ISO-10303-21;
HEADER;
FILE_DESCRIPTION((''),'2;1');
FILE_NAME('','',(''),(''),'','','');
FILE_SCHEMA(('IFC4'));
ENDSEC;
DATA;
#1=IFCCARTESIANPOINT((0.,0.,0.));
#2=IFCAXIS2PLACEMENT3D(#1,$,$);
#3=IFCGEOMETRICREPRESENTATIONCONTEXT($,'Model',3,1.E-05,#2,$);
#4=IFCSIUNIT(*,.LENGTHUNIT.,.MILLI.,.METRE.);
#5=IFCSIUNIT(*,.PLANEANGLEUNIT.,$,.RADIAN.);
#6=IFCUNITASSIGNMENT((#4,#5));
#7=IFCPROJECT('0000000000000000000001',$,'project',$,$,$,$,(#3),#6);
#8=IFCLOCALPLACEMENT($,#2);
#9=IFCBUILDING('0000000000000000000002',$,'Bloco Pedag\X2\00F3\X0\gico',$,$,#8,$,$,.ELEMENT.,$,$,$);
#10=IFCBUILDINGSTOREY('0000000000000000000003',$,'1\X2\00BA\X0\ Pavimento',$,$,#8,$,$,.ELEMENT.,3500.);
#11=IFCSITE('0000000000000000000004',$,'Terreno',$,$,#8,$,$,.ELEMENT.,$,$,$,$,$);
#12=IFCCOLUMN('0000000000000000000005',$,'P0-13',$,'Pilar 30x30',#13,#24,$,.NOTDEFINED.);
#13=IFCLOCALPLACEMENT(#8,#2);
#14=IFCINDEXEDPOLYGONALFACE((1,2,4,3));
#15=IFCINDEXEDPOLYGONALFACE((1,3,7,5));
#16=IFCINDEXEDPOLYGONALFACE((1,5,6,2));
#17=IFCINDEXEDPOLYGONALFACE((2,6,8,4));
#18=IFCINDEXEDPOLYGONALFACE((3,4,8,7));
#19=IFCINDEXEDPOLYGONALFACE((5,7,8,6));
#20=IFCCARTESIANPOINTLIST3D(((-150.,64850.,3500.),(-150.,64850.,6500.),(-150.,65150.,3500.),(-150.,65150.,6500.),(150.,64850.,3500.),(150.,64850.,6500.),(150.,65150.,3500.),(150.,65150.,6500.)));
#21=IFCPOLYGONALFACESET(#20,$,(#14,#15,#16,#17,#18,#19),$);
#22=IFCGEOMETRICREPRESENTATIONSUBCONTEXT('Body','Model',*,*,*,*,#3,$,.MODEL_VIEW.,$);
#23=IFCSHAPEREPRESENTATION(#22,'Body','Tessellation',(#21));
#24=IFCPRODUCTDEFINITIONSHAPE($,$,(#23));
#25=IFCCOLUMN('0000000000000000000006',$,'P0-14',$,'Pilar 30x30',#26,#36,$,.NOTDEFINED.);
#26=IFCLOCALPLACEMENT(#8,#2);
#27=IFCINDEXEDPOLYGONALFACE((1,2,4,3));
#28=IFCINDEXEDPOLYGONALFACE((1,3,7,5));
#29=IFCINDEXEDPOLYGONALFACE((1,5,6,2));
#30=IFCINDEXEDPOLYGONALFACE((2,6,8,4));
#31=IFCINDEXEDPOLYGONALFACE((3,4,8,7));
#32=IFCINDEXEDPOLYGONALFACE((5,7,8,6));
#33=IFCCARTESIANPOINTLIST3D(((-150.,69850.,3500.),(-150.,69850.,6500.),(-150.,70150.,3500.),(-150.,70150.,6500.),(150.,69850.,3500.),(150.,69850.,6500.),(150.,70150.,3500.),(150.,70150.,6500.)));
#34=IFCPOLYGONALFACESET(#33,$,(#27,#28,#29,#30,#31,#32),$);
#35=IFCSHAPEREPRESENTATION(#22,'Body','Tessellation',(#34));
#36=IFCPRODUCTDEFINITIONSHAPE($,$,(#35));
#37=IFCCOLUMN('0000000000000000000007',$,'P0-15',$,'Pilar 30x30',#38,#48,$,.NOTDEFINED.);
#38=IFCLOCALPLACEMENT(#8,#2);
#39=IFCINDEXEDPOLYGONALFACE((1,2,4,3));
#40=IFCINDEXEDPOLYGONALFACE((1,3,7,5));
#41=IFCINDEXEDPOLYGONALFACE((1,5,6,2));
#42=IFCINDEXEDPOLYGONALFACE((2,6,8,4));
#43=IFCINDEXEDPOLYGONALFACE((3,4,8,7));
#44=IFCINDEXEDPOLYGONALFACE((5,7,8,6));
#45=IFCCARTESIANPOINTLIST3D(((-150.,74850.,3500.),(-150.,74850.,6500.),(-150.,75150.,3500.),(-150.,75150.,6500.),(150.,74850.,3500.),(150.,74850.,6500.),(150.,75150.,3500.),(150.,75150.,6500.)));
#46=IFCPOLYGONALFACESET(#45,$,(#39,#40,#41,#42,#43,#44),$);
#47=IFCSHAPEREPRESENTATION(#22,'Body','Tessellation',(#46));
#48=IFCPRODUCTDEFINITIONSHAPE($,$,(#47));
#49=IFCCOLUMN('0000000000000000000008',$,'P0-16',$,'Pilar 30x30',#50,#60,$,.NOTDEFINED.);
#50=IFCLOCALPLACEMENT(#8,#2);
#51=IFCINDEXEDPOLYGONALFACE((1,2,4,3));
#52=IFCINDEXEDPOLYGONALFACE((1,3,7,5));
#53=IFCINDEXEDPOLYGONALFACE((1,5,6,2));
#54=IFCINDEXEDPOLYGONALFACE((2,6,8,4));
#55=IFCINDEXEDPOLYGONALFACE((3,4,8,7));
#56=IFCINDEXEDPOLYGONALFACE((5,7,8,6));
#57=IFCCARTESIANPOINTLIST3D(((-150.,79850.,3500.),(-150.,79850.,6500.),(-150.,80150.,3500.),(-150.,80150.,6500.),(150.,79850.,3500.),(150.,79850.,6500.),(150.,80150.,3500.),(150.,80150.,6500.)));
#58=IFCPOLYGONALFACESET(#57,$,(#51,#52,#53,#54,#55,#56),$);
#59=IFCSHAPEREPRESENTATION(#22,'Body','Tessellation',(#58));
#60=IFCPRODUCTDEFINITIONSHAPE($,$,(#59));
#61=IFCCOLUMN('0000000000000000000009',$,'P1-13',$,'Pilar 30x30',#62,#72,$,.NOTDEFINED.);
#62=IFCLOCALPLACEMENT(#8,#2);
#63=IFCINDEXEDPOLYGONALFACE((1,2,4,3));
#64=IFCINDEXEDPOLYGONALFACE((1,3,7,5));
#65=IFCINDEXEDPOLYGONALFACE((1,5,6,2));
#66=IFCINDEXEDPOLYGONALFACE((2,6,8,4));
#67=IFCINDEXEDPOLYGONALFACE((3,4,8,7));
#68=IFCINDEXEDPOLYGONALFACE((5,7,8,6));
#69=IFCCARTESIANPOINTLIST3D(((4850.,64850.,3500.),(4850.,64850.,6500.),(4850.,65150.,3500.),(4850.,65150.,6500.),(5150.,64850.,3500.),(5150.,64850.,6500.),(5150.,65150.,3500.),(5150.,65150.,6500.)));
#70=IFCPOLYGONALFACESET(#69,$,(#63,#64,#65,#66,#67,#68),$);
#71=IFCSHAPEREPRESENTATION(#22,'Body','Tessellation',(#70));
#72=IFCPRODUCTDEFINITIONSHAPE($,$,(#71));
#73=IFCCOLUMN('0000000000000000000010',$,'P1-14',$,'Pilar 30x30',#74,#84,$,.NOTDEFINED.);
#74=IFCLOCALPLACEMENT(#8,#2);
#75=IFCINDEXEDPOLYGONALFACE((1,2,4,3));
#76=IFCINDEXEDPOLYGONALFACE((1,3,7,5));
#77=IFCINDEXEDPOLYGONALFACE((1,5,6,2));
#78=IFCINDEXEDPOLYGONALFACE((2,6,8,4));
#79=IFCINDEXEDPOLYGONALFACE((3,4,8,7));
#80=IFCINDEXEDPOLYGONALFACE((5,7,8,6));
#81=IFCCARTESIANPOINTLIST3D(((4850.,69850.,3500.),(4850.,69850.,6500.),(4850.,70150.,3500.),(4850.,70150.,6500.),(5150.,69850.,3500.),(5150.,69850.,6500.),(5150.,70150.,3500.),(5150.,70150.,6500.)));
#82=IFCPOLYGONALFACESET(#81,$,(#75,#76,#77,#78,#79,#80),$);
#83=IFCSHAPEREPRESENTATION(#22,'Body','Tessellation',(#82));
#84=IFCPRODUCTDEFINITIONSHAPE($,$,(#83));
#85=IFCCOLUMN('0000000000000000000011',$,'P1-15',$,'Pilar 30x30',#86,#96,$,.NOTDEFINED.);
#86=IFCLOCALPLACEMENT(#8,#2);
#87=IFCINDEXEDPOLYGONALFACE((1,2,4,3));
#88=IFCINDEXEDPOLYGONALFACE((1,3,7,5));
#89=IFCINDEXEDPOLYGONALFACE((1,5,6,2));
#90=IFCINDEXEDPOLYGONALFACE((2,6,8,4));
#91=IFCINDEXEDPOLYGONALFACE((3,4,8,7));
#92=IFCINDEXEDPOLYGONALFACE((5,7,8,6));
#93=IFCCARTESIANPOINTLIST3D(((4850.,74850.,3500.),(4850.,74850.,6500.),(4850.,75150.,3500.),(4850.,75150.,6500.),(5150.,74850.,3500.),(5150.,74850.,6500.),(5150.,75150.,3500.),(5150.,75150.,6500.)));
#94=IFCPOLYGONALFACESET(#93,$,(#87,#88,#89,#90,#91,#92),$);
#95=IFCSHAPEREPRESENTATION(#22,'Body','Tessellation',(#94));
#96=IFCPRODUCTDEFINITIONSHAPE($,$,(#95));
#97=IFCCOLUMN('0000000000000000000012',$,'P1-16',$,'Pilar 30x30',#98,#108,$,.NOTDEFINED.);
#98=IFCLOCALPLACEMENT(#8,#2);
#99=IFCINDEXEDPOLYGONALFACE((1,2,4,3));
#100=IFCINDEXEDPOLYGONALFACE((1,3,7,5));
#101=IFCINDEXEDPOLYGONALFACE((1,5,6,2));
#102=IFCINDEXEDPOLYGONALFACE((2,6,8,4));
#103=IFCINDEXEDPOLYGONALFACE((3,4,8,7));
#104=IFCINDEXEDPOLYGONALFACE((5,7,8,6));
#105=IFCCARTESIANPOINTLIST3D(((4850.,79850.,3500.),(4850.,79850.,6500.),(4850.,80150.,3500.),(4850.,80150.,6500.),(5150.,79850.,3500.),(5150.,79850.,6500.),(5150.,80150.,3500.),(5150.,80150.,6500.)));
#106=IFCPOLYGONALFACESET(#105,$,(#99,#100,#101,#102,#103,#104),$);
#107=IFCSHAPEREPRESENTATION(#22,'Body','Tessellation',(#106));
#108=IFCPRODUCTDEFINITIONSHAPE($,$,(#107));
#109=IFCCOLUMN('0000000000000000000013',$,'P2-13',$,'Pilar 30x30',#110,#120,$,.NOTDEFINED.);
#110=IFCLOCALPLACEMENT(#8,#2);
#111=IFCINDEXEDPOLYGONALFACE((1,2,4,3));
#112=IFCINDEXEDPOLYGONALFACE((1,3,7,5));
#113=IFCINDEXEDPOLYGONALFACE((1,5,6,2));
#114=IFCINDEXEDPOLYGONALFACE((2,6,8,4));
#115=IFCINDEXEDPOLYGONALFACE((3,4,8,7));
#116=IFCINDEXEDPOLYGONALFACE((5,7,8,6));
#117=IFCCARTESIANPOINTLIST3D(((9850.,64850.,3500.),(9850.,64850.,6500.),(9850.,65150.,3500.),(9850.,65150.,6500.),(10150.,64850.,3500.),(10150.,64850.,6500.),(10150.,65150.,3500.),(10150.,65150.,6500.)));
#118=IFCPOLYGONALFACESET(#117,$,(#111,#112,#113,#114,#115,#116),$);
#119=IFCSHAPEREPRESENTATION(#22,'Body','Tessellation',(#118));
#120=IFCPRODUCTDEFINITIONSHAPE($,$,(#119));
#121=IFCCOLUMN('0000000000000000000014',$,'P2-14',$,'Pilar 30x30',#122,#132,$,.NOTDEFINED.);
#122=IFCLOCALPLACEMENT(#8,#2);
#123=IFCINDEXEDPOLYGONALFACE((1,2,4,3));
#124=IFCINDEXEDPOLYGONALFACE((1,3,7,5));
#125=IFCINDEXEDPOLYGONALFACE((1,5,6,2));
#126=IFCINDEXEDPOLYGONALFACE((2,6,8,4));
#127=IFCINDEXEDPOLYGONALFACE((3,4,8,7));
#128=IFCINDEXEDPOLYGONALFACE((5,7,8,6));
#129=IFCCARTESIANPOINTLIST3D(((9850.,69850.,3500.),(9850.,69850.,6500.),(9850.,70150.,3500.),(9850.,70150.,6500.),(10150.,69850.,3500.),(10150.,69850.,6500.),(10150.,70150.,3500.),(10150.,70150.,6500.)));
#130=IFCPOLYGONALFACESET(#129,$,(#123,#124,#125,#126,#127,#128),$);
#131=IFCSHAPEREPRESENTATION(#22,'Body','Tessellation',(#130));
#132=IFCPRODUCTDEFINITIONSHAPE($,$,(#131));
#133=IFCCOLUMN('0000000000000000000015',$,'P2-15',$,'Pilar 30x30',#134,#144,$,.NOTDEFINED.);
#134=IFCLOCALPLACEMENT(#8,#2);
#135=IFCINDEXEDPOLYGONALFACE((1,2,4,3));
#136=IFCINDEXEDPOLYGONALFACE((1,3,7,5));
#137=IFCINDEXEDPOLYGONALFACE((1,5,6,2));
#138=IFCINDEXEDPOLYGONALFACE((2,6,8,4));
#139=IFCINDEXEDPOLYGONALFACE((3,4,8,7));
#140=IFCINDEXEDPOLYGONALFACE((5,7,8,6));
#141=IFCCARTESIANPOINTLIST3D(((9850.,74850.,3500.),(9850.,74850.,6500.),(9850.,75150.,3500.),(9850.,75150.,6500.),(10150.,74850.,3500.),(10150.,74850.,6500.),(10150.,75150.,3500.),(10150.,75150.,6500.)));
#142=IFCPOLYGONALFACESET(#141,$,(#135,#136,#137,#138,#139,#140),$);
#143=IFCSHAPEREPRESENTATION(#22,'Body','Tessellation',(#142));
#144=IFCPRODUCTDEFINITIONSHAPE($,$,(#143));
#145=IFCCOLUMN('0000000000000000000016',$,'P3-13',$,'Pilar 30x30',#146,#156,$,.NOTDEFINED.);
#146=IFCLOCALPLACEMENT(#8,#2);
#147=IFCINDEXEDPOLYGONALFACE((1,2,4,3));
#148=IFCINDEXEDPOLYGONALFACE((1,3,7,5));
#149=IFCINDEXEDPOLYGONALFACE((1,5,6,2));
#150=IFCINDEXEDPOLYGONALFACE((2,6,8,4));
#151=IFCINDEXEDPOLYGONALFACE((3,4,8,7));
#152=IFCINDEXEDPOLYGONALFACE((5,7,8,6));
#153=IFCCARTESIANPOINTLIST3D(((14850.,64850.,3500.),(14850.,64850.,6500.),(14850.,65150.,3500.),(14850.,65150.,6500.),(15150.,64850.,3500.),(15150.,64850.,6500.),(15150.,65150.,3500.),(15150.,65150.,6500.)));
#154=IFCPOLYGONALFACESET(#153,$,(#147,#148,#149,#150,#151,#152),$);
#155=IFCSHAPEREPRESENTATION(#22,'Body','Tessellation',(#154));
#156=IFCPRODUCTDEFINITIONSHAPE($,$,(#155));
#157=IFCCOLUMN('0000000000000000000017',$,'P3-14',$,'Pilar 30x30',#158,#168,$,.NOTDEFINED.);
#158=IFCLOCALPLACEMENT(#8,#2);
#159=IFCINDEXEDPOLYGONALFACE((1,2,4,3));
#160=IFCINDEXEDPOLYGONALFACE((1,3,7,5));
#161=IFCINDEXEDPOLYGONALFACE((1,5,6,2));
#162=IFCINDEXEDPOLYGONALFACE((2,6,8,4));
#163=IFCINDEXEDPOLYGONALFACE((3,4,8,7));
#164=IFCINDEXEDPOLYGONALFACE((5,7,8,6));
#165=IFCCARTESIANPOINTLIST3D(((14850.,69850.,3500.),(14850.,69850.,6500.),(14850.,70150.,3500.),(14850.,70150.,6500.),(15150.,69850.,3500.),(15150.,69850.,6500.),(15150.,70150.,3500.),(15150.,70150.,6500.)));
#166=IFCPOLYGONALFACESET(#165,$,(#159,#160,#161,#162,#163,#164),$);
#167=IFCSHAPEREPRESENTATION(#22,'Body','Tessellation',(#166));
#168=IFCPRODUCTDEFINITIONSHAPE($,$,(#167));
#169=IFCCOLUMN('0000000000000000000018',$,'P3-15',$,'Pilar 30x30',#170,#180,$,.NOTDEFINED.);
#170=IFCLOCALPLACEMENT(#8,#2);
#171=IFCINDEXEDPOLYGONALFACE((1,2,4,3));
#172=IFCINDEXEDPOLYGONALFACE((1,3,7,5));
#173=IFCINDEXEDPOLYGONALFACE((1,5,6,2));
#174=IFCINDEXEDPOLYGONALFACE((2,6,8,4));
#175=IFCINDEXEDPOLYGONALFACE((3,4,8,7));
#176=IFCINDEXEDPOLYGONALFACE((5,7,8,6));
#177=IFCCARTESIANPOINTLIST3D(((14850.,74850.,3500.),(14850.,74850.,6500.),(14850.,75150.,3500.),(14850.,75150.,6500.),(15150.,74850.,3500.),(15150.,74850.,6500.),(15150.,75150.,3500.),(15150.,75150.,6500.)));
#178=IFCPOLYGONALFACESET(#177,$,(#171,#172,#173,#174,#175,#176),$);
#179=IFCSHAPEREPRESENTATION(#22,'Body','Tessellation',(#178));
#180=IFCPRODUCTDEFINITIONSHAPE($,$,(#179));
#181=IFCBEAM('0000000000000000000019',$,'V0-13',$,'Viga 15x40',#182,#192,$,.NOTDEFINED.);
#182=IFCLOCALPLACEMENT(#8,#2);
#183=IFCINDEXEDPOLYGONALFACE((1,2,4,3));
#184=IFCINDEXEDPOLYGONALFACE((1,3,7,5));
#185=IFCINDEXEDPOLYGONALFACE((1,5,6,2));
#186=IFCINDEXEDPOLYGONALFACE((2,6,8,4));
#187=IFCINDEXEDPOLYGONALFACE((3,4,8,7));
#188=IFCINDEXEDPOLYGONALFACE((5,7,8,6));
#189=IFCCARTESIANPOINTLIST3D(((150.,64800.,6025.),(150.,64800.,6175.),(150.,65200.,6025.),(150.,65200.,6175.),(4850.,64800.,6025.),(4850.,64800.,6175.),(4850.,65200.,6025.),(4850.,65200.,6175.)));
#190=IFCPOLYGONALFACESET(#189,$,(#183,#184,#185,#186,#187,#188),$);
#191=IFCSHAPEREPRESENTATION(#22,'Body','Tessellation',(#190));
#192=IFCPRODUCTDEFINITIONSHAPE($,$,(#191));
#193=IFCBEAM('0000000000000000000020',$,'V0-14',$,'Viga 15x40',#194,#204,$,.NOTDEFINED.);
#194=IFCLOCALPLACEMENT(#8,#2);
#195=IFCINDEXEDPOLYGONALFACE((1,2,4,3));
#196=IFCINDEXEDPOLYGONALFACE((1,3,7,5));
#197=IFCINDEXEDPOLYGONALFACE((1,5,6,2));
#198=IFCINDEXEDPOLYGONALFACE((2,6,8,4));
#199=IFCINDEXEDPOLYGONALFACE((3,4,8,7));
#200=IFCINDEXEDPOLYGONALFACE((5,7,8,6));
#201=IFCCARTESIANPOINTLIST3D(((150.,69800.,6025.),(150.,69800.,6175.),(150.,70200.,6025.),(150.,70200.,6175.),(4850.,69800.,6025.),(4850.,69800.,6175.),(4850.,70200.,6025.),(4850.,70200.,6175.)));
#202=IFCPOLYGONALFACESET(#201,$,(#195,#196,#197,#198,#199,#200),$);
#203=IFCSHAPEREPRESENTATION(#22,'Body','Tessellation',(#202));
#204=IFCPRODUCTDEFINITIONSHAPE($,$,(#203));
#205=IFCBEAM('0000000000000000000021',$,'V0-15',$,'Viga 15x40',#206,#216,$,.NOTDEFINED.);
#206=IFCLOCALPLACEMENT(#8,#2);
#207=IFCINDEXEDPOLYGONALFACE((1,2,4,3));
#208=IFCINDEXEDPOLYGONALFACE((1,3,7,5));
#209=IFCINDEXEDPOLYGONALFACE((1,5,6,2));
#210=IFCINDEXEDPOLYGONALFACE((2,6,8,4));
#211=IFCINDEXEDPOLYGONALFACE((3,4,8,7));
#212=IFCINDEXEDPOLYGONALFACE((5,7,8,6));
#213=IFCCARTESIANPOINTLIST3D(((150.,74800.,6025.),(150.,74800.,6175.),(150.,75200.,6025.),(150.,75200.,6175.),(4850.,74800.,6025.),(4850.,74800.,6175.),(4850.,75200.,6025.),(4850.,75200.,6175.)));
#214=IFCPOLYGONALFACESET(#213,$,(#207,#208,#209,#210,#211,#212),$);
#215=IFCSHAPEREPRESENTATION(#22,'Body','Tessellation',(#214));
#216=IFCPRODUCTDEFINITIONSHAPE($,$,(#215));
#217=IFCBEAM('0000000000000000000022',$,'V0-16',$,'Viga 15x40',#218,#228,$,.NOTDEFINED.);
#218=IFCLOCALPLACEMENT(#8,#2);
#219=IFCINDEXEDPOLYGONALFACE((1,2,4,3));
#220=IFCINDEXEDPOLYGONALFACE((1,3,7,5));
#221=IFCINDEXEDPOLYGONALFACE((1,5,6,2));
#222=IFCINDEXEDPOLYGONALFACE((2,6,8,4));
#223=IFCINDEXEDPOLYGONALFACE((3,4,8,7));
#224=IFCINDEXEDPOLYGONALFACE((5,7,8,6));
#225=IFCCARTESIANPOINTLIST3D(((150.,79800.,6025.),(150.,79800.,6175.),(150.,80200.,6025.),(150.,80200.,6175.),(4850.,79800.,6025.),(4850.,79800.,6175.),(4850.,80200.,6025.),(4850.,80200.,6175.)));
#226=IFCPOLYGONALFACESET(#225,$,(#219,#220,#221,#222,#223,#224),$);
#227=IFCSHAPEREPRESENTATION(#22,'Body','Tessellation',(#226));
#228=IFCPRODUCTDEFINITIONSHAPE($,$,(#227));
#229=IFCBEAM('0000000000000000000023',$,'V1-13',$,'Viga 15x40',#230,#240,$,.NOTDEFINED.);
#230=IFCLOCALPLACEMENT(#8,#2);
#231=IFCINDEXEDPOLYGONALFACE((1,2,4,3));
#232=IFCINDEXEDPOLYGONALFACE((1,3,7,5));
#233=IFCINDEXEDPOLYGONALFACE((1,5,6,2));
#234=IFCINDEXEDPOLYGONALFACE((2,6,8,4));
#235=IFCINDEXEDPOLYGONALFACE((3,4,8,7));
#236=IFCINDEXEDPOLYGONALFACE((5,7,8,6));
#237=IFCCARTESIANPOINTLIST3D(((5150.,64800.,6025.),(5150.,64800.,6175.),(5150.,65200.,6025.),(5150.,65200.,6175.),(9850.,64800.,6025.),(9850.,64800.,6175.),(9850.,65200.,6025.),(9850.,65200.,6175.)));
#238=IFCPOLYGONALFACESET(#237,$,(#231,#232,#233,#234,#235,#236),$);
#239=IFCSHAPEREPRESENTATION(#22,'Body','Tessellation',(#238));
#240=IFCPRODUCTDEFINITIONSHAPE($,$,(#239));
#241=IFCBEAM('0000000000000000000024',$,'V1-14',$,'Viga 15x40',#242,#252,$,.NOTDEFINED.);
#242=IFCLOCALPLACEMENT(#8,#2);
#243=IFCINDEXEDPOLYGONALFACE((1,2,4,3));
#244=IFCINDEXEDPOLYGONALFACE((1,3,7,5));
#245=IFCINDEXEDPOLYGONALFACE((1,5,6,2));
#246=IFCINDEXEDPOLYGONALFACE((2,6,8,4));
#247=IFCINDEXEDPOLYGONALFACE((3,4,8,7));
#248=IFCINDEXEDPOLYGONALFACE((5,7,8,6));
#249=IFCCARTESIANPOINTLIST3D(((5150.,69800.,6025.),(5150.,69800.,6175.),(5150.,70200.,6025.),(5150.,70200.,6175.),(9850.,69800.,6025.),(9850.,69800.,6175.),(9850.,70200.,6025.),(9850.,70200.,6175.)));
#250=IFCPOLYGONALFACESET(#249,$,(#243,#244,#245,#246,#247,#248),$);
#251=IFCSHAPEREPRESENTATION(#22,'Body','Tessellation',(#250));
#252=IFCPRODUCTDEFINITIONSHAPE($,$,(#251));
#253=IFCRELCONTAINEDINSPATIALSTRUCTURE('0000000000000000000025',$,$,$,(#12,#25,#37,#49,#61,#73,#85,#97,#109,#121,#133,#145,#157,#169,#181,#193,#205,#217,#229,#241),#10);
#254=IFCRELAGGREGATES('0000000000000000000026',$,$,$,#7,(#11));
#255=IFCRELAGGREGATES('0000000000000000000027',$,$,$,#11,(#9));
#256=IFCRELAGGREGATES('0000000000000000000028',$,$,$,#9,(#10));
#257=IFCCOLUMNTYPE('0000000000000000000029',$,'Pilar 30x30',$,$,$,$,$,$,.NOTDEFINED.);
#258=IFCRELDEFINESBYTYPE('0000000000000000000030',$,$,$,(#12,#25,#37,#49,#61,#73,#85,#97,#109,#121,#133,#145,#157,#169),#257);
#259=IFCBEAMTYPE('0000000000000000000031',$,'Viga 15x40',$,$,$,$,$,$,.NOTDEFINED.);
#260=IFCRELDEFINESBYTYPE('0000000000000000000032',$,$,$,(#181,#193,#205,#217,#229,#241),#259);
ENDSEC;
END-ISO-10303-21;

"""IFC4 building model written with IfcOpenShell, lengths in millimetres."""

from ifc_helpers import new_model, si_unit, frame, origin, origin_2d, place, context, subcontext, project, spatial, rectangle, extrude, type_object, element, save


model = new_model("IFC4")

# Units and contexts
model_context = context("Model", 3, precision=1e-05, world=origin())
body_context = subcontext(model_context, "Body", "Model", "MODEL_VIEW")
ifc_project = project(units=[si_unit("LENGTHUNIT", "METRE", prefix="MILLI"), si_unit("PLANEANGLEUNIT", "RADIAN")], contexts=[model_context])

# Site, building, storey
placement = place(None, origin())
site = spatial("IfcSite", under=ifc_project, at=placement, Name="Terreno", CompositionType="ELEMENT")
building = spatial("IfcBuilding", under=site, at=placement, Name="Bloco Pedagógico", CompositionType="ELEMENT")
storey = spatial("IfcBuildingStorey", under=building, at=placement, Name="1º Pavimento", CompositionType="ELEMENT", Elevation=3500.0)

# Columns
column_type = type_object("IfcColumnType", Name="Pilar 30x30", PredefinedType="NOTDEFINED")
for number, where, z_axis, x_axis, name in (
    (1, (0.0, 65000.0, 3500.0), (0.0, 0.0, 1.0), (1.0, 0.0, 0.0), "P0-13"),
    (2, (0.0, 70000.0, 3500.0), (0.0, 0.0, 1.0), (1.0, 0.0, 0.0), "P0-14"),
    (3, (0.0, 75000.0, 3500.0), (0.0, 0.0, 1.0), (1.0, 0.0, 0.0), "P0-15"),
    (4, (0.0, 80000.0, 3500.0), (0.0, 0.0, 1.0), (1.0, 0.0, 0.0), "P0-16"),
    (5, (5000.0, 65000.0, 3500.0), (0.0, 0.0, 1.0), (1.0, 0.0, 0.0), "P1-13"),
    (6, (5000.0, 70000.0, 3500.0), (0.0, 0.0, 1.0), (1.0, 0.0, 0.0), "P1-14"),
    (7, (5000.0, 75000.0, 3500.0), (0.0, 0.0, 1.0), (1.0, 0.0, 0.0), "P1-15"),
    (8, (5000.0, 80000.0, 3500.0), (0.0, 0.0, 1.0), (1.0, 0.0, 0.0), "P1-16"),
    (9, (10000.0, 65000.0, 3500.0), (0.0, 0.0, 1.0), (1.0, 0.0, 0.0), "P2-13"),
    (10, (10000.0, 70000.0, 3500.0), (0.0, 0.0, 1.0), (1.0, 0.0, 0.0), "P2-14"),
    (11, (10000.0, 75000.0, 3500.0), (0.0, 0.0, 1.0), (1.0, 0.0, 0.0), "P2-15"),
    (12, (15000.0, 65000.0, 3500.0), (0.0, 0.0, 1.0), (1.0, 0.0, 0.0), "P3-13"),
    (13, (15000.0, 70000.0, 3500.0), (0.0, 0.0, 1.0), (1.0, 0.0, 0.0), "P3-14"),
    (14, (15000.0, 75000.0, 3500.0), (0.0, 0.0, 1.0), (1.0, 0.0, 0.0), "P3-15"),
):
    element("IfcColumn", number, at=place(None, frame(where, z_axis=z_axis, x_axis=x_axis)), inside=storey, type_object=column_type, Name=name, ObjectType="Pilar 30x30", PredefinedType="NOTDEFINED", context=body_context, shape_type="SweptSolid", body=[
        extrude(rectangle(XDim=300.0, YDim=300.0, at=origin_2d()), None, (0.0, 0.0, 1.0), 3000.0),
    ])

# Beams
beam_type = type_object("IfcBeamType", Name="Viga 15x40", PredefinedType="NOTDEFINED")
for number, where, z_axis, x_axis, name in (
    (15, (150.0, 65000.0, 6100.0), (1.0, 0.0, 0.0), (0.0, 1.0, 0.0), "V0-13"),
    (16, (150.0, 70000.0, 6100.0), (1.0, 0.0, 0.0), (0.0, 1.0, 0.0), "V0-14"),
    (17, (150.0, 75000.0, 6100.0), (1.0, 0.0, 0.0), (0.0, 1.0, 0.0), "V0-15"),
    (18, (150.0, 80000.0, 6100.0), (1.0, 0.0, 0.0), (0.0, 1.0, 0.0), "V0-16"),
    (19, (5150.0, 65000.0, 6100.0), (1.0, 0.0, 0.0), (0.0, 1.0, 0.0), "V1-13"),
    (20, (5150.0, 70000.0, 6100.0), (1.0, 0.0, 0.0), (0.0, 1.0, 0.0), "V1-14"),
):
    element("IfcBeam", number, at=place(None, frame(where, z_axis=z_axis, x_axis=x_axis)), inside=storey, type_object=beam_type, Name=name, ObjectType="Viga 15x40", PredefinedType="NOTDEFINED", context=body_context, shape_type="SweptSolid", body=[
        extrude(rectangle(XDim=400.0, YDim=150.0, at=origin_2d()), None, (0.0, 0.0, 1.0), 4700.0),
    ])

save(model, "model.ifc")
